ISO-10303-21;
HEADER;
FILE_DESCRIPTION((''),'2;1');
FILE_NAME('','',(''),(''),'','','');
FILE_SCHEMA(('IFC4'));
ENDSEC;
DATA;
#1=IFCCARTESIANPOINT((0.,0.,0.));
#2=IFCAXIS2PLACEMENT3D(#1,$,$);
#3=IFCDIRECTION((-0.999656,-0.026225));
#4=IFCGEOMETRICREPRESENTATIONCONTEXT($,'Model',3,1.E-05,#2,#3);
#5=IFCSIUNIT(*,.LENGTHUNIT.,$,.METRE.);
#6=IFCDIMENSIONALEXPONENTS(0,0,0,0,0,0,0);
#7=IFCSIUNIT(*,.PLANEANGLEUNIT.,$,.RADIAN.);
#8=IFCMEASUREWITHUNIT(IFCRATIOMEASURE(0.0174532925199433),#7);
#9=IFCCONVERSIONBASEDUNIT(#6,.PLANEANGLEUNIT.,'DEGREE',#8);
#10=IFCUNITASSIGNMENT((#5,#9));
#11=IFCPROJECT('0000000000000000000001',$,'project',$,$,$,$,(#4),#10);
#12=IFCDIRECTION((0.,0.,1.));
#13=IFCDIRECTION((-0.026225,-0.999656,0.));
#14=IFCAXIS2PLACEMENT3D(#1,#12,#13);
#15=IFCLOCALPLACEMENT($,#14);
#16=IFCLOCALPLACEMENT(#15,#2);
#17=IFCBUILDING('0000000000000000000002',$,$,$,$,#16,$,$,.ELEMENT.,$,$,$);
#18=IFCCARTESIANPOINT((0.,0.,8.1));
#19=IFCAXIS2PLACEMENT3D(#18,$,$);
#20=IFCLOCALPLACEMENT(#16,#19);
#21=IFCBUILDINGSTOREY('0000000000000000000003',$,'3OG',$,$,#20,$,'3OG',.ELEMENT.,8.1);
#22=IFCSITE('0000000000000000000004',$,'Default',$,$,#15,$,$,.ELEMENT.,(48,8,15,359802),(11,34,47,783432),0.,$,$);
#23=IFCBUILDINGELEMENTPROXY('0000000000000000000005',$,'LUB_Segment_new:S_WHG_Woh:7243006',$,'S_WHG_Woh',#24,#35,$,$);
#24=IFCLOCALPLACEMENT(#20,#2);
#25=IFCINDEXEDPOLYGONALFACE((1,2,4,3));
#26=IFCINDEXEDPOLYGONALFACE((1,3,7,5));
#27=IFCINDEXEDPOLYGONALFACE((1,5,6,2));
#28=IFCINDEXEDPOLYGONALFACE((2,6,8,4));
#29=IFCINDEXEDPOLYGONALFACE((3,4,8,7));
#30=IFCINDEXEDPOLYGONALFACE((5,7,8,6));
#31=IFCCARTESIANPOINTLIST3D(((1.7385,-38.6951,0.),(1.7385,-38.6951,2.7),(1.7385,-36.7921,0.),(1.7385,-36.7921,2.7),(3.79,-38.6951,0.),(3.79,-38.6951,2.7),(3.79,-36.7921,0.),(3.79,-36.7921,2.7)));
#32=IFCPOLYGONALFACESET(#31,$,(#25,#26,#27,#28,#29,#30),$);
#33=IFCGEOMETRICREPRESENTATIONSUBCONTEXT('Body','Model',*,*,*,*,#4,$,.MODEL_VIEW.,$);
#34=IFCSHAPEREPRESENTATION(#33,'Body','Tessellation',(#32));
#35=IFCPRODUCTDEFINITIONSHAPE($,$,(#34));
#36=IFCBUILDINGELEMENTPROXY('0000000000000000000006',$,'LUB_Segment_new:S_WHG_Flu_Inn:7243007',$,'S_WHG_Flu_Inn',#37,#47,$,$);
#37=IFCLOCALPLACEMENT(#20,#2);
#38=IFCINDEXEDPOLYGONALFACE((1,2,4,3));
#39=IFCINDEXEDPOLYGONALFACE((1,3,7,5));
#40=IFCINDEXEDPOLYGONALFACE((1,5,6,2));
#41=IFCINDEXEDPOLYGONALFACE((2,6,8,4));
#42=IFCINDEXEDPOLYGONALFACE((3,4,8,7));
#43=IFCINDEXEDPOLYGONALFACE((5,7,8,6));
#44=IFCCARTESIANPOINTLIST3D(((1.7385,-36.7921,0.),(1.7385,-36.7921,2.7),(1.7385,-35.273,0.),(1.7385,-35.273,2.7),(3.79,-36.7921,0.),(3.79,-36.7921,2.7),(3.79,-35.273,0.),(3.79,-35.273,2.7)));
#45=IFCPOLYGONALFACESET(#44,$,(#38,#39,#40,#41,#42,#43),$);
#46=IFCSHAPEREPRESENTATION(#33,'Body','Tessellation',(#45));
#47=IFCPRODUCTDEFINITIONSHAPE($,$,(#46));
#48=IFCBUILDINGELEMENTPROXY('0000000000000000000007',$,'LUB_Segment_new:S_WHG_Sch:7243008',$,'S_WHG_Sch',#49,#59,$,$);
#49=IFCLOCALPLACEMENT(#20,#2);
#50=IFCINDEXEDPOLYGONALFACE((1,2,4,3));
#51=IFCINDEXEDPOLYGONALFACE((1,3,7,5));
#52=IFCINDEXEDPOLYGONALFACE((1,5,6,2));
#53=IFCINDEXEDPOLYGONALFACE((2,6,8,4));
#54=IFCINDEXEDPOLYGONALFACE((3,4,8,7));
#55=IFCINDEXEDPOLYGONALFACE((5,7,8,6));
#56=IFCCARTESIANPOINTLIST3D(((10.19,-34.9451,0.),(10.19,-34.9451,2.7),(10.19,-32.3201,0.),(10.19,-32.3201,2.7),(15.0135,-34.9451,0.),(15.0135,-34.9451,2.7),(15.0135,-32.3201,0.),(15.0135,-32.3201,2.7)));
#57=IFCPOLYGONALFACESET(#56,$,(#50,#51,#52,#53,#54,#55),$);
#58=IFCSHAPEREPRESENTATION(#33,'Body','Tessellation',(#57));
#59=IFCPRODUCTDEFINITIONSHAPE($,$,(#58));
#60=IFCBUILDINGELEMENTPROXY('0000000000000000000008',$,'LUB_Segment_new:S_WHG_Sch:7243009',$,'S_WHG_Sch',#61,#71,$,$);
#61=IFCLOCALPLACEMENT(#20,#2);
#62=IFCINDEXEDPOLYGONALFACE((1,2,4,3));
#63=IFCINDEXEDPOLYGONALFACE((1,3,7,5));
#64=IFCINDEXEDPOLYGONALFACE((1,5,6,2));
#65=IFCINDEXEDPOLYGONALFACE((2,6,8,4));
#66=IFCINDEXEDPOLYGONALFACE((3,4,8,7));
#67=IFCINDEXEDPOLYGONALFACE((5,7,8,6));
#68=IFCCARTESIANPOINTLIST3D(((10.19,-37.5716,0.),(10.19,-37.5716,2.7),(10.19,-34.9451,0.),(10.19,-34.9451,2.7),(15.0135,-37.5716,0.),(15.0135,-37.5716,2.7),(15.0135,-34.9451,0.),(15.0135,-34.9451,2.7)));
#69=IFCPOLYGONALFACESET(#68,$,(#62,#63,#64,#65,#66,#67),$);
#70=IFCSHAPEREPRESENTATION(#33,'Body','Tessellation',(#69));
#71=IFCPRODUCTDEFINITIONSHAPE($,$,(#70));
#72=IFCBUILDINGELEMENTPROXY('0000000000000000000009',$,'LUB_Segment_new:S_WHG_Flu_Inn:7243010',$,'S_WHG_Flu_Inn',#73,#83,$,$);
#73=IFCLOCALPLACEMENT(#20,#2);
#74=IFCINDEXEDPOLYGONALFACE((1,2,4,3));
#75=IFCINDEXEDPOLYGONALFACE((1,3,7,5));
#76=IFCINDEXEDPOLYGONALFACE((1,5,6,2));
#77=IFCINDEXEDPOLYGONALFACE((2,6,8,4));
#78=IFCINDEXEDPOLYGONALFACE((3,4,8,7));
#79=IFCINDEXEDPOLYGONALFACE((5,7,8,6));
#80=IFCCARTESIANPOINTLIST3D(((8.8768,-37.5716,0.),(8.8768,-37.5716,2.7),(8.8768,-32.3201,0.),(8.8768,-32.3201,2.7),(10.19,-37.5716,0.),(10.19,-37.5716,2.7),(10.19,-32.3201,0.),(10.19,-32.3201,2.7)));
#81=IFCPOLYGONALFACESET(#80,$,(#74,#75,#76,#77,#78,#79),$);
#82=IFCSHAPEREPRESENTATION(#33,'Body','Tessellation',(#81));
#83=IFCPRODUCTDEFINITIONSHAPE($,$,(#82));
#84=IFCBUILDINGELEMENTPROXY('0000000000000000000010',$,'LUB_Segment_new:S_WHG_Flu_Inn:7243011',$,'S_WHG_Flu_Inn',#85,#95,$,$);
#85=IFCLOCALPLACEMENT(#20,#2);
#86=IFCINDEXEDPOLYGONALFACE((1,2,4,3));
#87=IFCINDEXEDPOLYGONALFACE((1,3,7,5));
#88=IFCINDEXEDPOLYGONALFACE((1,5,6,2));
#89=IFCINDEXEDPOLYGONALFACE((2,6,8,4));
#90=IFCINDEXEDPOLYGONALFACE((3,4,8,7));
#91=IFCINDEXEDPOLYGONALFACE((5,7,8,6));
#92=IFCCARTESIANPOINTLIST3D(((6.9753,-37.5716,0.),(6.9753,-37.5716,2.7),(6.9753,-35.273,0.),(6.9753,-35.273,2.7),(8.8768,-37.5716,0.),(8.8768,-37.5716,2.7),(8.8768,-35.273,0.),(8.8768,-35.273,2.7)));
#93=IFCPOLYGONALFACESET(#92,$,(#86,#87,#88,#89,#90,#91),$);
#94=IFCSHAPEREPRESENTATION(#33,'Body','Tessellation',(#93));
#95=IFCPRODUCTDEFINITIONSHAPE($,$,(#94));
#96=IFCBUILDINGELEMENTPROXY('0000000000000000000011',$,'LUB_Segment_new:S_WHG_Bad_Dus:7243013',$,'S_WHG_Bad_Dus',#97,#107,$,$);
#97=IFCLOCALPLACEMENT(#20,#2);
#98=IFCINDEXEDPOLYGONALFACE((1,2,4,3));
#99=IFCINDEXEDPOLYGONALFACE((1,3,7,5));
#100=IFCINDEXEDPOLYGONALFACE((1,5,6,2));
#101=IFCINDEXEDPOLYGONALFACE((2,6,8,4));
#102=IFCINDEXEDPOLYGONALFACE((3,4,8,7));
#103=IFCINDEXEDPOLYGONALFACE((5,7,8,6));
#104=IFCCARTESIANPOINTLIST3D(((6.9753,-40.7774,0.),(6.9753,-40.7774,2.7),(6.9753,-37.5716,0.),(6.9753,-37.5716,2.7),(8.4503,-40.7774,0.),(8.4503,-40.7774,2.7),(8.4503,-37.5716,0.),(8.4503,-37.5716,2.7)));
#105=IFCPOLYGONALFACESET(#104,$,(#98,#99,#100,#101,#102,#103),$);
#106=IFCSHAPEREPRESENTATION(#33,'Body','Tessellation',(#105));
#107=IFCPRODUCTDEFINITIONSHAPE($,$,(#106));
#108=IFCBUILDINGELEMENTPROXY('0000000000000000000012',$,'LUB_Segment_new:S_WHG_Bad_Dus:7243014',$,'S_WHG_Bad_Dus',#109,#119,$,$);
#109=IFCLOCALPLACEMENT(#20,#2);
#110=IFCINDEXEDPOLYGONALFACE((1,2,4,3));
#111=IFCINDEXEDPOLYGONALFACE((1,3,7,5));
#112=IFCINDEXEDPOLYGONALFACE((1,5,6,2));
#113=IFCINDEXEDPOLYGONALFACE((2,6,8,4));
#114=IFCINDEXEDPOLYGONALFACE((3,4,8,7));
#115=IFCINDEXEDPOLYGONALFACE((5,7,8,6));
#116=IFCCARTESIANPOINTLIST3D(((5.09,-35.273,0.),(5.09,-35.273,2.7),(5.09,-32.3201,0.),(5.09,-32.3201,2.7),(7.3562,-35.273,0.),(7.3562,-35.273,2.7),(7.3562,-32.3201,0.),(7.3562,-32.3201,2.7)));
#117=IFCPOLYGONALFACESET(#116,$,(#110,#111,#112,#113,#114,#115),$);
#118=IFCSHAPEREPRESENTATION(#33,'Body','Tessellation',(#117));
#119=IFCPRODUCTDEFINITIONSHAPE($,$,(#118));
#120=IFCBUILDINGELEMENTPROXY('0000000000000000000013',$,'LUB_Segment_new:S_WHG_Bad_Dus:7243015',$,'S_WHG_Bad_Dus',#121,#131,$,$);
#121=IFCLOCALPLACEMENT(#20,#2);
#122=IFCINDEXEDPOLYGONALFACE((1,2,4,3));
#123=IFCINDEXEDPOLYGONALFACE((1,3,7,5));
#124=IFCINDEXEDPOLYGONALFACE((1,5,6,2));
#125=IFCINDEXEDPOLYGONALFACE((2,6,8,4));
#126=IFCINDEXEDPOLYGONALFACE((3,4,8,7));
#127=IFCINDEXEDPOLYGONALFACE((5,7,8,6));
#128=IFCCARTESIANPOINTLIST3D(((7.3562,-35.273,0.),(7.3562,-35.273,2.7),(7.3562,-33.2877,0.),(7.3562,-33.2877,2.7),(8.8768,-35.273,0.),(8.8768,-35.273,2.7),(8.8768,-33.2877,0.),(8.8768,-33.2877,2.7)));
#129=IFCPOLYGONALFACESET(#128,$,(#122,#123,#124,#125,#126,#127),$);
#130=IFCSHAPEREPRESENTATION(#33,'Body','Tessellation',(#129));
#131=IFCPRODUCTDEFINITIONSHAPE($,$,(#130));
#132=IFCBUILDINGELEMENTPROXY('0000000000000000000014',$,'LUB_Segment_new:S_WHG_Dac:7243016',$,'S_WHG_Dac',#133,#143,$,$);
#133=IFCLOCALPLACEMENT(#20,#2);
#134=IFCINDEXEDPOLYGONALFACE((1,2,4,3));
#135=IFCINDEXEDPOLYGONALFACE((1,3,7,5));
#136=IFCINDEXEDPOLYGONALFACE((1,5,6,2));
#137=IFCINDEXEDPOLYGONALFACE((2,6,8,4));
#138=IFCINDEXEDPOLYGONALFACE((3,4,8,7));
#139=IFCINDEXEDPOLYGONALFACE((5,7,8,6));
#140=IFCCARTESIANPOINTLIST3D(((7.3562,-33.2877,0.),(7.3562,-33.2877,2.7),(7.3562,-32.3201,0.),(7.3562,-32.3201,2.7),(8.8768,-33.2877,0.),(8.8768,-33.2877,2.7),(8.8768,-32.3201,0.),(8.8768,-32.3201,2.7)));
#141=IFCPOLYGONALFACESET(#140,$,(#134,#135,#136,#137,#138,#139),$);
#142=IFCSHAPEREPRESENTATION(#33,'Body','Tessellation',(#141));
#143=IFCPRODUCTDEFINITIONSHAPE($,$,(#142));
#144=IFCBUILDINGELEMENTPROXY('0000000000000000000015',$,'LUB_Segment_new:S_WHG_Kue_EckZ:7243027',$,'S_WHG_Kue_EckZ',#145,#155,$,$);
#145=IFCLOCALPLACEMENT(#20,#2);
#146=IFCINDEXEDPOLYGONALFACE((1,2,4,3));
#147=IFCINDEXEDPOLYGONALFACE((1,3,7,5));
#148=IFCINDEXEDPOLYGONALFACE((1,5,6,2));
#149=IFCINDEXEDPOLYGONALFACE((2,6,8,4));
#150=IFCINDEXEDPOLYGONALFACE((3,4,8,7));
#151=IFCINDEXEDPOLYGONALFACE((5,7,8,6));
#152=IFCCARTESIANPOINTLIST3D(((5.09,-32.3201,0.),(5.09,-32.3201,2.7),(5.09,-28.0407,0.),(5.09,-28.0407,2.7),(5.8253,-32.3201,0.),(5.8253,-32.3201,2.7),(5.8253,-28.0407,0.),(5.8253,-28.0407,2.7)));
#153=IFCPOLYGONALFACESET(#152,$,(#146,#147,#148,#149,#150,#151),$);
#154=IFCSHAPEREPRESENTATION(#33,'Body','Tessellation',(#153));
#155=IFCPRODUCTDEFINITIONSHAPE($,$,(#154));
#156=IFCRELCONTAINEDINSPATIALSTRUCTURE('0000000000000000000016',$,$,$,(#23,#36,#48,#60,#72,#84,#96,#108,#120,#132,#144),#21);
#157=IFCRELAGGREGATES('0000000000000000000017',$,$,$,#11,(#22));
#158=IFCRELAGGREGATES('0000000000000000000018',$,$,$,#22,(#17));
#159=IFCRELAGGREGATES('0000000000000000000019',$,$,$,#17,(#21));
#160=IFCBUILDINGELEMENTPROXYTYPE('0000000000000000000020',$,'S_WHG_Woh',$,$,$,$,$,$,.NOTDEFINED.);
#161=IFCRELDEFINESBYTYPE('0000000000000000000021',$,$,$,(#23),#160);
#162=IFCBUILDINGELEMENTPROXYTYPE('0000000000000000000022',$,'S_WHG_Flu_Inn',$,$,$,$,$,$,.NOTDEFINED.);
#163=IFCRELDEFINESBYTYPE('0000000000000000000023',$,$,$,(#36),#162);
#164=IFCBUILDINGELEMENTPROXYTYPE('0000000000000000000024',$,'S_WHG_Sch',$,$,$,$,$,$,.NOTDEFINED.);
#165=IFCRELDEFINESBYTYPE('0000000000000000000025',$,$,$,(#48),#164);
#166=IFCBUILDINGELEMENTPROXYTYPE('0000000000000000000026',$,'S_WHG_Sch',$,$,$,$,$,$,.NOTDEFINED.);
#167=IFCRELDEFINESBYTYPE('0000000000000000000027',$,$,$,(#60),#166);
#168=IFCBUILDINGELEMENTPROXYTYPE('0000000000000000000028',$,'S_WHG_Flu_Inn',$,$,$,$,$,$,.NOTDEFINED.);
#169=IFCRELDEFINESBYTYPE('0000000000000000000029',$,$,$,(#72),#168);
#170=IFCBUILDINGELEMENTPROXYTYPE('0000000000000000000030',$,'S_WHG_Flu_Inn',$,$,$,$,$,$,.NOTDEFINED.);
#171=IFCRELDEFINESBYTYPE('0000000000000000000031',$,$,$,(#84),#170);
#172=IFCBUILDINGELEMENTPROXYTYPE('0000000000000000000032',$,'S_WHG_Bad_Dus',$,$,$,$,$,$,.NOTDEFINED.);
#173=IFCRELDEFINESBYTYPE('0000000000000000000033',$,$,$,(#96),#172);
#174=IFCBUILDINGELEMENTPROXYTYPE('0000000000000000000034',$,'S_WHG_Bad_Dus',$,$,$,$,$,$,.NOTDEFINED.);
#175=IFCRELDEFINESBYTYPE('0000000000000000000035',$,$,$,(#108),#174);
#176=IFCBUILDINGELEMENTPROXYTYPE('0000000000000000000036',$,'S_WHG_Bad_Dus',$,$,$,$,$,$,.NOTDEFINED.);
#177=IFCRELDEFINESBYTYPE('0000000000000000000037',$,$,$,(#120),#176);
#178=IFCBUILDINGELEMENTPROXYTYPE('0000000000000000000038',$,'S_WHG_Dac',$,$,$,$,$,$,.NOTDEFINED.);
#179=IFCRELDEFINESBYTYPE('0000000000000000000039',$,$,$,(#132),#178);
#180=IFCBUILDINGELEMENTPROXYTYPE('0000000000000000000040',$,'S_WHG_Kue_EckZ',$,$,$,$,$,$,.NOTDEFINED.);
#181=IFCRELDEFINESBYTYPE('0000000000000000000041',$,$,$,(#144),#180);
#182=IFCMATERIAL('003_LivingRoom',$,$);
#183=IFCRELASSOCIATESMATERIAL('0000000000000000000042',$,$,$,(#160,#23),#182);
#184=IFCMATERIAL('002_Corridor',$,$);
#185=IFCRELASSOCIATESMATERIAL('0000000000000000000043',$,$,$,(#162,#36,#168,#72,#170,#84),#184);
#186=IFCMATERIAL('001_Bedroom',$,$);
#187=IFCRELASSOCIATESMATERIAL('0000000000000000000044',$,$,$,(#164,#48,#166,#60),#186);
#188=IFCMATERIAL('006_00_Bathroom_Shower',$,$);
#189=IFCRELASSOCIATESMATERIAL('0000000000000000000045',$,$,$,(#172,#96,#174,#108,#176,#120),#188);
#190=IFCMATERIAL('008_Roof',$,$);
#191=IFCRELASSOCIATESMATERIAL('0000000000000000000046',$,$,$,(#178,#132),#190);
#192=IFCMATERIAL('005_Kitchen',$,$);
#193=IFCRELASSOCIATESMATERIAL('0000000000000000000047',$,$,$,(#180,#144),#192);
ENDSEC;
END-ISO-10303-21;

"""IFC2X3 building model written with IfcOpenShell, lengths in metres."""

from ifc_helpers import new_model, entity, si_unit, converted_unit, direction, frame, frame_2d, origin, origin_2d_with_axis, place, context, subcontext, project, spatial, rectangle, extrude, source, transform, mapped, material, type_object, type_shapes, element, save


model = new_model("IFC2X3")

# Units and contexts
model_context = context("Model", 3, precision=1e-05, world=origin(), true_north=direction((-0.999656, -0.026225)))
body_context = subcontext(model_context, "Body", "Model", "MODEL_VIEW")
ifc_project = project(units=[si_unit("LENGTHUNIT", "METRE"), converted_unit("PLANEANGLEUNIT", "DEGREE", entity("IfcRatioMeasure", 0.0174532925199433), si_unit("PLANEANGLEUNIT", "RADIAN"), dimensions=[0, 0, 0, 0, 0, 0, 0])], contexts=[model_context])

# Site, building, storey
site_placement = place(None, frame((0.0, 0.0, 0.0), z_axis=(0.0, 0.0, 1.0), x_axis=(-0.026225, -0.999656, 0.0)))
site = spatial("IfcSite", under=ifc_project, at=site_placement, Name="Default", CompositionType="ELEMENT", RefLatitude=(48, 8, 15, 359802), RefLongitude=(11, 34, 47, 783432), RefElevation=0.0)
building_placement = place(site_placement, origin())
building = spatial("IfcBuilding", under=site, at=building_placement, CompositionType="ELEMENT")
storey_placement = place(building_placement, frame((0.0, 0.0, 8.1)))
storey = spatial("IfcBuildingStorey", under=building, at=storey_placement, Name="3OG", LongName="3OG", CompositionType="ELEMENT", Elevation=8.1)

# Building element proxies
ifc_material_1 = material(Name="001_Bedroom")
ifc_material_2 = material(Name="002_Corridor")
ifc_material_3 = material(Name="006_00_Bathroom_Shower")
ifc_material_4 = material(Name="005_Kitchen")
ifc_material_5 = material(Name="003_LivingRoom")
building_element_proxy_type_1 = type_object("IfcBuildingElementProxyType", Name="S_WHG_Woh", PredefinedType="NOTDEFINED", material=ifc_material_5)
shared_shape_1 = source(origin(), body_context, "Body", "SweptSolid", [
    extrude(rectangle(XDim=2.0515, YDim=1.9029, at=origin_2d_with_axis()), frame((0.0, 0.0, 0.0), z_axis=(0.0, 0.0, 1.0), x_axis=(-1.0, 0.0, 0.0)), (0.0, 0.0, 1.0), 2.7),
])
type_shapes(building_element_proxy_type_1, [shared_shape_1])
proxy_1_placement = place(storey_placement, frame((2.7643, -37.7436, 0.0)))
element("IfcBuildingElementProxy", 1, at=proxy_1_placement, inside=storey, type_object=building_element_proxy_type_1, material=ifc_material_5, Name="LUB_Segment_new:S_WHG_Woh:7243006", ObjectType="S_WHG_Woh", context=body_context, shape_type="MappedRepresentation", body=[
    mapped(shared_shape_1, transform((0.0, 0.0, 0.0), scale=1.0)),
])
building_element_proxy_type_2 = type_object("IfcBuildingElementProxyType", Name="S_WHG_Flu_Inn", PredefinedType="NOTDEFINED", material=ifc_material_2)
shared_shape_2 = source(origin(), body_context, "Body", "SweptSolid", [
    extrude(rectangle(XDim=2.0515, YDim=1.5191, at=origin_2d_with_axis()), frame((0.0, 0.0, 0.0), z_axis=(0.0, 0.0, 1.0), x_axis=(-1.0, 0.0, 0.0)), (0.0, 0.0, 1.0), 2.7),
])
type_shapes(building_element_proxy_type_2, [shared_shape_2])
proxy_2_placement = place(storey_placement, frame((2.7643, -36.0326, 0.0)))
element("IfcBuildingElementProxy", 2, at=proxy_2_placement, inside=storey, type_object=building_element_proxy_type_2, material=ifc_material_2, Name="LUB_Segment_new:S_WHG_Flu_Inn:7243007", ObjectType="S_WHG_Flu_Inn", context=body_context, shape_type="MappedRepresentation", body=[
    mapped(shared_shape_2, transform((0.0, 0.0, 0.0), scale=1.0)),
])
building_element_proxy_type_3 = type_object("IfcBuildingElementProxyType", Name="S_WHG_Sch", PredefinedType="NOTDEFINED", material=ifc_material_1)
shared_shape_3 = source(origin(), body_context, "Body", "SweptSolid", [
    extrude(rectangle(XDim=4.8235, YDim=2.625, at=origin_2d_with_axis()), frame((0.0, 0.0, 0.0), z_axis=(0.0, 0.0, 1.0), x_axis=(-1.0, 0.0, 0.0)), (0.0, 0.0, 1.0), 2.7),
])
type_shapes(building_element_proxy_type_3, [shared_shape_3])
proxy_3_placement = place(storey_placement, frame((12.6018, -33.6326, 0.0)))
element("IfcBuildingElementProxy", 3, at=proxy_3_placement, inside=storey, type_object=building_element_proxy_type_3, material=ifc_material_1, Name="LUB_Segment_new:S_WHG_Sch:7243008", ObjectType="S_WHG_Sch", context=body_context, shape_type="MappedRepresentation", body=[
    mapped(shared_shape_3, transform((0.0, 0.0, 0.0), scale=1.0)),
])
building_element_proxy_type_4 = type_object("IfcBuildingElementProxyType", Name="S_WHG_Sch", PredefinedType="NOTDEFINED", material=ifc_material_1)
shared_shape_4 = source(origin(), body_context, "Body", "SweptSolid", [
    extrude(rectangle(XDim=4.8235, YDim=2.6265, at=origin_2d_with_axis()), frame((0.0, 0.0, 0.0), z_axis=(0.0, 0.0, 1.0), x_axis=(-1.0, 0.0, 0.0)), (0.0, 0.0, 1.0), 2.7),
])
type_shapes(building_element_proxy_type_4, [shared_shape_4])
proxy_4_placement = place(storey_placement, frame((12.6018, -36.2583, 0.0)))
element("IfcBuildingElementProxy", 4, at=proxy_4_placement, inside=storey, type_object=building_element_proxy_type_4, material=ifc_material_1, Name="LUB_Segment_new:S_WHG_Sch:7243009", ObjectType="S_WHG_Sch", context=body_context, shape_type="MappedRepresentation", body=[
    mapped(shared_shape_4, transform((0.0, 0.0, 0.0), scale=1.0)),
])
building_element_proxy_type_5 = type_object("IfcBuildingElementProxyType", Name="S_WHG_Flu_Inn", PredefinedType="NOTDEFINED", material=ifc_material_2)
shared_shape_5 = source(origin(), body_context, "Body", "SweptSolid", [
    extrude(rectangle(XDim=1.3132, YDim=5.2515, at=origin_2d_with_axis()), frame((0.0, 0.0, 0.0), z_axis=(0.0, 0.0, 1.0), x_axis=(-1.0, 0.0, 0.0)), (0.0, 0.0, 1.0), 2.7),
])
type_shapes(building_element_proxy_type_5, [shared_shape_5])
proxy_5_placement = place(storey_placement, frame((9.5334, -34.9458, 0.0)))
element("IfcBuildingElementProxy", 5, at=proxy_5_placement, inside=storey, type_object=building_element_proxy_type_5, material=ifc_material_2, Name="LUB_Segment_new:S_WHG_Flu_Inn:7243010", ObjectType="S_WHG_Flu_Inn", context=body_context, shape_type="MappedRepresentation", body=[
    mapped(shared_shape_5, transform((0.0, 0.0, 0.0), scale=1.0)),
])
building_element_proxy_type_6 = type_object("IfcBuildingElementProxyType", Name="S_WHG_Flu_Inn", PredefinedType="NOTDEFINED", material=ifc_material_2)
shared_shape_6 = source(origin(), body_context, "Body", "SweptSolid", [
    extrude(rectangle(XDim=1.9015, YDim=2.2985, at=origin_2d_with_axis()), frame((0.0, 0.0, 0.0), z_axis=(0.0, 0.0, 1.0), x_axis=(-1.0, 0.0, 0.0)), (0.0, 0.0, 1.0), 2.7),
])
type_shapes(building_element_proxy_type_6, [shared_shape_6])
proxy_6_placement = place(storey_placement, frame((7.926, -36.4223, 0.0)))
element("IfcBuildingElementProxy", 6, at=proxy_6_placement, inside=storey, type_object=building_element_proxy_type_6, material=ifc_material_2, Name="LUB_Segment_new:S_WHG_Flu_Inn:7243011", ObjectType="S_WHG_Flu_Inn", context=body_context, shape_type="MappedRepresentation", body=[
    mapped(shared_shape_6, transform((0.0, 0.0, 0.0), scale=1.0)),
])
building_element_proxy_type_7 = type_object("IfcBuildingElementProxyType", Name="S_WHG_Bad_Dus", PredefinedType="NOTDEFINED", material=ifc_material_3)
shared_shape_7 = source(origin(), body_context, "Body", "SweptSolid", [
    extrude(rectangle(XDim=3.2059, YDim=1.475, at=origin_2d_with_axis()), frame((0.0, 0.0, 0.0), z_axis=(0.0, 0.0, 1.0), x_axis=(0.0, 1.0, 0.0)), (0.0, 0.0, 1.0), 2.7),
])
type_shapes(building_element_proxy_type_7, [shared_shape_7])
proxy_7_placement = place(storey_placement, frame((7.7128, -39.1745, 0.0)))
element("IfcBuildingElementProxy", 7, at=proxy_7_placement, inside=storey, type_object=building_element_proxy_type_7, material=ifc_material_3, Name="LUB_Segment_new:S_WHG_Bad_Dus:7243013", ObjectType="S_WHG_Bad_Dus", context=body_context, shape_type="MappedRepresentation", body=[
    mapped(shared_shape_7, transform((0.0, 0.0, 0.0), scale=1.0)),
])
building_element_proxy_type_8 = type_object("IfcBuildingElementProxyType", Name="S_WHG_Bad_Dus", PredefinedType="NOTDEFINED", material=ifc_material_3)
shared_shape_8 = source(origin(), body_context, "Body", "SweptSolid", [
    extrude(rectangle(XDim=2.9529, YDim=2.2662, at=origin_2d_with_axis()), frame((0.0, 0.0, 0.0), z_axis=(0.0, 0.0, 1.0), x_axis=(0.0, 1.0, 0.0)), (0.0, 0.0, 1.0), 2.7),
])
type_shapes(building_element_proxy_type_8, [shared_shape_8])
proxy_8_placement = place(storey_placement, frame((6.2231, -33.7966, 0.0)))
element("IfcBuildingElementProxy", 8, at=proxy_8_placement, inside=storey, type_object=building_element_proxy_type_8, material=ifc_material_3, Name="LUB_Segment_new:S_WHG_Bad_Dus:7243014", ObjectType="S_WHG_Bad_Dus", context=body_context, shape_type="MappedRepresentation", body=[
    mapped(shared_shape_8, transform((0.0, 0.0, 0.0), scale=1.0)),
])
building_element_proxy_type_9 = type_object("IfcBuildingElementProxyType", Name="S_WHG_Bad_Dus", PredefinedType="NOTDEFINED", material=ifc_material_3)
shared_shape_9 = source(origin(), body_context, "Body", "SweptSolid", [
    extrude(rectangle(XDim=1.9853, YDim=1.5206, at=origin_2d_with_axis()), frame((0.0, 0.0, 0.0), z_axis=(0.0, 0.0, 1.0), x_axis=(0.0, 1.0, 0.0)), (0.0, 0.0, 1.0), 2.7),
])
type_shapes(building_element_proxy_type_9, [shared_shape_9])
proxy_9_placement = place(storey_placement, frame((8.1165, -34.2804, 0.0)))
element("IfcBuildingElementProxy", 9, at=proxy_9_placement, inside=storey, type_object=building_element_proxy_type_9, material=ifc_material_3, Name="LUB_Segment_new:S_WHG_Bad_Dus:7243015", ObjectType="S_WHG_Bad_Dus", context=body_context, shape_type="MappedRepresentation", body=[
    mapped(shared_shape_9, transform((0.0, 0.0, 0.0), scale=1.0)),
])
ifc_material_6 = material(Name="008_Roof")
building_element_proxy_type_10 = type_object("IfcBuildingElementProxyType", Name="S_WHG_Dac", PredefinedType="NOTDEFINED", material=ifc_material_6)
shared_shape_10 = source(origin(), body_context, "Body", "SweptSolid", [
    extrude(rectangle(XDim=0.9676, YDim=1.5206, at=frame_2d((0.0, 0.0), x_axis=(1.0, 0.0))), frame((0.0, 0.0, 0.0), z_axis=(0.0, 0.0, 1.0), x_axis=(0.0, 1.0, 0.0)), (0.0, 0.0, 1.0), 2.7),
])
type_shapes(building_element_proxy_type_10, [shared_shape_10])
proxy_10_placement = place(storey_placement, frame((8.1165, -32.8039, 0.0)))
element("IfcBuildingElementProxy", 10, at=proxy_10_placement, inside=storey, type_object=building_element_proxy_type_10, material=ifc_material_6, Name="LUB_Segment_new:S_WHG_Dac:7243016", ObjectType="S_WHG_Dac", context=body_context, shape_type="MappedRepresentation", body=[
    mapped(shared_shape_10, transform((0.0, 0.0, 0.0), scale=1.0)),
])
building_element_proxy_type_11 = type_object("IfcBuildingElementProxyType", Name="S_WHG_Kue_EckZ", PredefinedType="NOTDEFINED", material=ifc_material_4)
shared_shape_11 = source(origin(), body_context, "Body", "SweptSolid", [
    extrude(rectangle(XDim=4.2794, YDim=0.7353, at=origin_2d_with_axis()), frame((0.0, 0.0, 0.0), z_axis=(0.0, 0.0, 1.0), x_axis=(0.0, 1.0, 0.0)), (0.0, 0.0, 1.0), 2.7),
])
type_shapes(building_element_proxy_type_11, [shared_shape_11])
proxy_11_placement = place(storey_placement, frame((5.4577, -30.1804, 0.0)))
element("IfcBuildingElementProxy", 11, at=proxy_11_placement, inside=storey, type_object=building_element_proxy_type_11, material=ifc_material_4, Name="LUB_Segment_new:S_WHG_Kue_EckZ:7243027", ObjectType="S_WHG_Kue_EckZ", context=body_context, shape_type="MappedRepresentation", body=[
    mapped(shared_shape_11, transform((0.0, 0.0, 0.0), scale=1.0)),
])

save(model, "model.ifc")
